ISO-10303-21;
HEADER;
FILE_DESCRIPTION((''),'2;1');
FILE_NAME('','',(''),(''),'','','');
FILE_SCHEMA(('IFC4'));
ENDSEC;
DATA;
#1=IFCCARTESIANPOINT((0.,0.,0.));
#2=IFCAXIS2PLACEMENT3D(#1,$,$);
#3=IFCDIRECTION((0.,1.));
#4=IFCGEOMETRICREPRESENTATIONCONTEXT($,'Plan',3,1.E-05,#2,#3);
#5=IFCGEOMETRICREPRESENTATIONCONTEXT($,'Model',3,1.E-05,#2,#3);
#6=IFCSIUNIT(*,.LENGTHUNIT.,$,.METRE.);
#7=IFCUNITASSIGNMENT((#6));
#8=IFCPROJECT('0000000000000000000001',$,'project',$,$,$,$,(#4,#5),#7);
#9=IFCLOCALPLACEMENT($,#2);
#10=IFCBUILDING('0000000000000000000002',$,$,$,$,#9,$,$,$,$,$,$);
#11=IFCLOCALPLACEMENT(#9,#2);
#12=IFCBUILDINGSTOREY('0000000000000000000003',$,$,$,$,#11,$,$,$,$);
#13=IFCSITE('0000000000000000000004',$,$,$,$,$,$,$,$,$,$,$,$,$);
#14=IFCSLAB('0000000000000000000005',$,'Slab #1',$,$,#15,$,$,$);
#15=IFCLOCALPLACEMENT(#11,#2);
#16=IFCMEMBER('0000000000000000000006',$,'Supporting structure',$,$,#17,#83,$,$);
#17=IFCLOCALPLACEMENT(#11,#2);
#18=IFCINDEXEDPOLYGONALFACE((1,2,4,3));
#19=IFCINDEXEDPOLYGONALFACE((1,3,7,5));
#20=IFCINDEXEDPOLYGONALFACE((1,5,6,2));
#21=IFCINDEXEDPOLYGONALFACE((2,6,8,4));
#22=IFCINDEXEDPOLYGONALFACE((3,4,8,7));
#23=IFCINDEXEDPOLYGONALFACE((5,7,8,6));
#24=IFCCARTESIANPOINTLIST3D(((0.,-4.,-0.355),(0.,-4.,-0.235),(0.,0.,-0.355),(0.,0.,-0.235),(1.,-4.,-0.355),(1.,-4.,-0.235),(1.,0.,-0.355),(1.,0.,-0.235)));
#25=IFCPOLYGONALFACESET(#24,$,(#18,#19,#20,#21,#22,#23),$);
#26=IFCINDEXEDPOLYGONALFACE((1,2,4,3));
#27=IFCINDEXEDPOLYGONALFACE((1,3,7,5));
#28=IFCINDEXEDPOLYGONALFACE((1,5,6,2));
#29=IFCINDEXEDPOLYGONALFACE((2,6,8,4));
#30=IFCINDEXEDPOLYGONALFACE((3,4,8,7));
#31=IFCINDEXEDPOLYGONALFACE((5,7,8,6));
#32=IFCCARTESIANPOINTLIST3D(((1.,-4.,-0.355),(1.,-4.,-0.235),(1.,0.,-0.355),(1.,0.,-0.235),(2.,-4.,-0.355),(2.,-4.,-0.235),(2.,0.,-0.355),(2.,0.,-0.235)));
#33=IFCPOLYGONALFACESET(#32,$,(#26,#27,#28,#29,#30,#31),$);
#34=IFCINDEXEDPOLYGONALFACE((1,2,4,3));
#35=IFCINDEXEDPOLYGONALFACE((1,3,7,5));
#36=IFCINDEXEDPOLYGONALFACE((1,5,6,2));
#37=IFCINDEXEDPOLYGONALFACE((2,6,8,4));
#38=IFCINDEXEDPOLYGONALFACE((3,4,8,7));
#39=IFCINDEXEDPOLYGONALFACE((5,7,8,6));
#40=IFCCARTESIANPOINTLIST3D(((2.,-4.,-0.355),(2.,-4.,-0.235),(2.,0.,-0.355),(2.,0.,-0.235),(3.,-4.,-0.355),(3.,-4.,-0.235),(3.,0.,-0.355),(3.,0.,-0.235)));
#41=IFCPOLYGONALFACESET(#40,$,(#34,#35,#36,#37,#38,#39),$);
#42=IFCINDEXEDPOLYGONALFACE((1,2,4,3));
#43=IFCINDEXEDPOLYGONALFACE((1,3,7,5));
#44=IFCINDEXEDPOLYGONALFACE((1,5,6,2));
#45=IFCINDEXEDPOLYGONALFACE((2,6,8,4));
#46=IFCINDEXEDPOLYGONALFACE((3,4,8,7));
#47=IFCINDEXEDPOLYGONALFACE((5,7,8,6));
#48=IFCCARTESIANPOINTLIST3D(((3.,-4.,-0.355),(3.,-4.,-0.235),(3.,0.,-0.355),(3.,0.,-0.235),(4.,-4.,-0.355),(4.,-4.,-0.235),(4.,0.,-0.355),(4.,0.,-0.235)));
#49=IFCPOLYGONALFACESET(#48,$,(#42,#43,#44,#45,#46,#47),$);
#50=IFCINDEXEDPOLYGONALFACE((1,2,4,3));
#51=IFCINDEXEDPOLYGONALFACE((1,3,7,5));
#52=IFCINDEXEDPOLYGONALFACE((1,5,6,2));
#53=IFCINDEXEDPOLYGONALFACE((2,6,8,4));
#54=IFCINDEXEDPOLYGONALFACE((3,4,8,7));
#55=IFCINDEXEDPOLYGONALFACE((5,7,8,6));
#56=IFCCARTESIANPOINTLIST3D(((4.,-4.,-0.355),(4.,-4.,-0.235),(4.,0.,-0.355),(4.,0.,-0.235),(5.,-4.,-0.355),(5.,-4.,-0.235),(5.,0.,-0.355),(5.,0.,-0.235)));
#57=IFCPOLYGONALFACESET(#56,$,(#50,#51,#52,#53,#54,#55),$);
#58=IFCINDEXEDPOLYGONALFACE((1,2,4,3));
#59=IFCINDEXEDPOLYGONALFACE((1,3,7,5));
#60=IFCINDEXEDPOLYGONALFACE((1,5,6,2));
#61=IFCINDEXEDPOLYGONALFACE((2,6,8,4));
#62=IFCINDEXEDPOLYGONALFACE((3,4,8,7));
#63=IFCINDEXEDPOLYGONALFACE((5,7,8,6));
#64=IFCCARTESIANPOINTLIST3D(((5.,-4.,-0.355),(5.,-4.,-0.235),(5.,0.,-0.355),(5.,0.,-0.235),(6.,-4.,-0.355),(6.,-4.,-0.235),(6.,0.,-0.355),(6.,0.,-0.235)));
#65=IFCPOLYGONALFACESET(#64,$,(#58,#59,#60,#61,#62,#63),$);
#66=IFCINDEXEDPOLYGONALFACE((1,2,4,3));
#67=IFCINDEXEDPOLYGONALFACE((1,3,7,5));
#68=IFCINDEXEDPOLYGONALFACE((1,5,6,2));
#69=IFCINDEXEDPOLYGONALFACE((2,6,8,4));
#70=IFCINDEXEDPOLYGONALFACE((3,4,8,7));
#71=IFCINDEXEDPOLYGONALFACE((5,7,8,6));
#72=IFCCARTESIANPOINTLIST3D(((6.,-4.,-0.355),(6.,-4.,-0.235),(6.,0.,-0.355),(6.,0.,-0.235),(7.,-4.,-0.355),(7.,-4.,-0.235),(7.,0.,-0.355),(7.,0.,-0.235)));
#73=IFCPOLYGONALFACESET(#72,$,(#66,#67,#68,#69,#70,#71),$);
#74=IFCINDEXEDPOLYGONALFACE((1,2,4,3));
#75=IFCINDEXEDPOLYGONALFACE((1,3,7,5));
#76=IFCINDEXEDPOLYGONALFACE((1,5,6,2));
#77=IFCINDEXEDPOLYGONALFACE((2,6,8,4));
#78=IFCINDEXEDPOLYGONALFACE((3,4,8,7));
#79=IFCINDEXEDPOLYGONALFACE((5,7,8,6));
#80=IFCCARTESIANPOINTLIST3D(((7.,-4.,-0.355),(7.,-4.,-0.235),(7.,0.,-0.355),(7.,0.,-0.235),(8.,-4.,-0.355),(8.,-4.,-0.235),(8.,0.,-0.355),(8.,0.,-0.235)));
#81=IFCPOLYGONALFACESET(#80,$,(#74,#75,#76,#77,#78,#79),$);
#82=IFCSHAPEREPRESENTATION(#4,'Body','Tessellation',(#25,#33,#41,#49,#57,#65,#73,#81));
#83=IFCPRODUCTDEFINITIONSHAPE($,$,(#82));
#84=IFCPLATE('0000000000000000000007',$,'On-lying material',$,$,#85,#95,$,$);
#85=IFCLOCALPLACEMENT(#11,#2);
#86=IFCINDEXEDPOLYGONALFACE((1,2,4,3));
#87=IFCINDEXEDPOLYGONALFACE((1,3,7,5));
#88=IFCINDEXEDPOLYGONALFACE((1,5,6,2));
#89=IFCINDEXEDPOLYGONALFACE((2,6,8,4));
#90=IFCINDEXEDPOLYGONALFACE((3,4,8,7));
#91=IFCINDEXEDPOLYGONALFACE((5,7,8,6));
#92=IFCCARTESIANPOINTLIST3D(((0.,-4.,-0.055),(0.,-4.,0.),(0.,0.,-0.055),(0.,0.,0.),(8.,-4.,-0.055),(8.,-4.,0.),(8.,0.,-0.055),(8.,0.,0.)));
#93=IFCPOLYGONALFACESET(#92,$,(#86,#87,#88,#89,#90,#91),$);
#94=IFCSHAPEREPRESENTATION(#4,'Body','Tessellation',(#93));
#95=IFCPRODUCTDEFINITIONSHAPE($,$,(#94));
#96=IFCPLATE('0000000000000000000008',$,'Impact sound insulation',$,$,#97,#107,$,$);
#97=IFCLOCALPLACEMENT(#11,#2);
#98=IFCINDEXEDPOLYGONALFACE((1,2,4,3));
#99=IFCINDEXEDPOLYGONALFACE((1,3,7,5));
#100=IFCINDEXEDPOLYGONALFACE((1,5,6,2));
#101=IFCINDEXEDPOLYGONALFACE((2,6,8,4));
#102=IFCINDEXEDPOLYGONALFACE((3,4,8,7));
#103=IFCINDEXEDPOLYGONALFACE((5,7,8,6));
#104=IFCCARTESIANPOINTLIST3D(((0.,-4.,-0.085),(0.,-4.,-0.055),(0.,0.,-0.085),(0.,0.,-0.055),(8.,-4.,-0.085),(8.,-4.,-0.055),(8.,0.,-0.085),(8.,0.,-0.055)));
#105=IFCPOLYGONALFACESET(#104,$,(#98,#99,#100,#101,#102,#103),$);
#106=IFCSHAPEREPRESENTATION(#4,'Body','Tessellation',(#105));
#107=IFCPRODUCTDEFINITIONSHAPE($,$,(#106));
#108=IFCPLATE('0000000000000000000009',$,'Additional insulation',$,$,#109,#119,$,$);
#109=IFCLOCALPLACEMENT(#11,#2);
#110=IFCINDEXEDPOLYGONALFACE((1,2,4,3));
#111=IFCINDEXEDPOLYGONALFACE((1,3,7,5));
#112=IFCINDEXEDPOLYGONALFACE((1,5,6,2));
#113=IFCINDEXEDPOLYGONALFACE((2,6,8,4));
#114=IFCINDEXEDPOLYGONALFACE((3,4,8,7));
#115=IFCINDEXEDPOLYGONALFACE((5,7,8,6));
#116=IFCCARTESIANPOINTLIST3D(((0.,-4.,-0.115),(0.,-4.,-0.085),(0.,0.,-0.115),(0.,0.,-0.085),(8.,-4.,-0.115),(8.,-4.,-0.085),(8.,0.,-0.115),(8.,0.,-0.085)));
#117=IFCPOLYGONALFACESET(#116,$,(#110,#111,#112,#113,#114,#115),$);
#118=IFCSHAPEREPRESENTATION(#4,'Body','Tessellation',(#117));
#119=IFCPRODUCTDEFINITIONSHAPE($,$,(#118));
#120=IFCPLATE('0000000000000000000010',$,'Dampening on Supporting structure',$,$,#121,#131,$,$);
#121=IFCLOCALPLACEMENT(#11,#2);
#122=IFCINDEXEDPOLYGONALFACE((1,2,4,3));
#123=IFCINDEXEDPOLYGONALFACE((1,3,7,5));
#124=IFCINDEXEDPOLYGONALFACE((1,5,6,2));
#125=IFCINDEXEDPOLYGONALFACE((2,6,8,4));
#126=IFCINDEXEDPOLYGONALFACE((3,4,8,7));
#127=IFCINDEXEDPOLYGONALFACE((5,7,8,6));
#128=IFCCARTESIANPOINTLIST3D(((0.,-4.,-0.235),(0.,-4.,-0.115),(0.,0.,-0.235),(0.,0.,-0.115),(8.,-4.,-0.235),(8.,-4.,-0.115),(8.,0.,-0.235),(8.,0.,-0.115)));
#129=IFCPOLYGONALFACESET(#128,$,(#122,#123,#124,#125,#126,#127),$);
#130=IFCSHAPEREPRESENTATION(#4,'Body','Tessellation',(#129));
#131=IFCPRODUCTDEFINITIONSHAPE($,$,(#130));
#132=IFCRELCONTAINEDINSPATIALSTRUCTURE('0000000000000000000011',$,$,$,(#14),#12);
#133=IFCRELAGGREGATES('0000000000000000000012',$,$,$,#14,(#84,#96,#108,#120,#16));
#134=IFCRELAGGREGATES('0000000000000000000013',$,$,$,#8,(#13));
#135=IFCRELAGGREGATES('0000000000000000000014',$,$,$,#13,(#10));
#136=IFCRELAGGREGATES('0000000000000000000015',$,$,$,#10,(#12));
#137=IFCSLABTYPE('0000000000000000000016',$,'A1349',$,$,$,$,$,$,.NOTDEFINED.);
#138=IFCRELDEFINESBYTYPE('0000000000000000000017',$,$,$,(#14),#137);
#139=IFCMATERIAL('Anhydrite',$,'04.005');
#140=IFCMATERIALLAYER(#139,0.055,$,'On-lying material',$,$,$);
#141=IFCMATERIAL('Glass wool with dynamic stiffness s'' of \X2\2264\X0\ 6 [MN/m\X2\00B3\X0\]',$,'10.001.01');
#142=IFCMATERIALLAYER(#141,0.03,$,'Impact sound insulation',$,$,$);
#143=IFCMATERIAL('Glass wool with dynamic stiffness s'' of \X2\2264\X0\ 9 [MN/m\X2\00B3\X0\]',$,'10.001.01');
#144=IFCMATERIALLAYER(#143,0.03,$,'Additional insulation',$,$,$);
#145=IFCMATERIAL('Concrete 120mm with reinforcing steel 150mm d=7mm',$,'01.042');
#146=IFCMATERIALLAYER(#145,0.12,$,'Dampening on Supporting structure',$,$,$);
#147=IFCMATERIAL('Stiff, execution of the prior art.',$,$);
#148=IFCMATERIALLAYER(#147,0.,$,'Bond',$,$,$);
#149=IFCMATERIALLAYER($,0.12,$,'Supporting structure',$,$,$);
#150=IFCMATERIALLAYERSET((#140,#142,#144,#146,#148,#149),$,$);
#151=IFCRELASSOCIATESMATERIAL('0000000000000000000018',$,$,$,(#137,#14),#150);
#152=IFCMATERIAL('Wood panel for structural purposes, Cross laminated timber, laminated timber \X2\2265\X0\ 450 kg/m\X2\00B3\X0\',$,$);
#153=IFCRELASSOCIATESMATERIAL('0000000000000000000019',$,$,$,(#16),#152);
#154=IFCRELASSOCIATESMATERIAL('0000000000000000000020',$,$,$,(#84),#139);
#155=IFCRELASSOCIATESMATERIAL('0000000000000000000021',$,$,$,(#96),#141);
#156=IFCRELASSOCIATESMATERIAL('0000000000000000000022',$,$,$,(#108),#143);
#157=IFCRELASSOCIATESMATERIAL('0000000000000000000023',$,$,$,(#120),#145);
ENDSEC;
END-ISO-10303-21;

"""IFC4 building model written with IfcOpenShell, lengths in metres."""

from ifc_helpers import new_model, si_unit, direction, frame, frame_2d, origin, origin_with_axes, place, context, project, spatial, rectangle, extrude, material, layer, layer_set, type_object, element, aggregate, save


model = new_model("IFC4")

# Units and contexts
plan_context = context("Plan", 3, precision=1e-05, world=origin(), true_north=direction((0.0, 1.0)))
model_context = context("Model", 3, precision=1e-05, world=origin(), true_north=direction((0.0, 1.0)))
ifc_project = project(units=[si_unit("LENGTHUNIT", "METRE")], contexts=[plan_context, model_context])

# Site, building, storey
site = spatial("IfcSite", under=ifc_project)
building_placement = place(None, origin())
building = spatial("IfcBuilding", under=site, at=building_placement)
storey_placement = place(building_placement, origin())
storey = spatial("IfcBuildingStorey", under=building, at=storey_placement)

# Slab, member, plates
ifc_material_1 = material(Name="Anhydrite", Category="04.005")
ifc_layer_1 = layer(ifc_material_1, 0.055, Name="On-lying material")
ifc_material_2 = material(Name="Glass wool with dynamic stiffness s' of ≤ 6 [MN/m³]", Category="10.001.01")
ifc_layer_2 = layer(ifc_material_2, 0.03, Name="Impact sound insulation")
ifc_material_3 = material(Name="Glass wool with dynamic stiffness s' of ≤ 9 [MN/m³]", Category="10.001.01")
ifc_layer_3 = layer(ifc_material_3, 0.03, Name="Additional insulation")
ifc_material_4 = material(Name="Concrete 120mm with reinforcing steel 150mm d=7mm", Category="01.042")
ifc_layer_4 = layer(ifc_material_4, 0.12, Name="Dampening on Supporting structure")
ifc_material_5 = material(Name="Stiff, execution of the prior art.")
ifc_layer_5 = layer(ifc_material_5, 0.0, Name="Bond")
ifc_layer_6 = layer(None, 0.12, Name="Supporting structure")
ifc_layer_set = layer_set([ifc_layer_1, ifc_layer_2, ifc_layer_3, ifc_layer_4, ifc_layer_5, ifc_layer_6])
slab_type = type_object("IfcSlabType", Name="A1349", PredefinedType="NOTDEFINED", material=ifc_layer_set)
slab_placement = place(None, frame((0.0, 0.0, 0.0), z_axis=(0.0, 0.0, -1.0), x_axis=(1.0, 0.0, 0.0)))
slab = element("IfcSlab", 1, at=slab_placement, inside=storey, type_object=slab_type, material=ifc_layer_set, Name="Slab #1")
ifc_material_6 = material(Name="Wood panel for structural purposes, Cross laminated timber, laminated timber ≥ 450 kg/m³")
member_placement = place(slab_placement, origin())
member = element("IfcMember", 2, at=member_placement, material=ifc_material_6, Name="Supporting structure", context=plan_context, shape_type="SweptSolid", body=[
    extrude(rectangle(XDim=1.0, YDim=0.12, at=frame_2d((0.5, 0.06), x_axis=(1.0, 0.0))), frame((0.0, 4.0, 0.235), z_axis=(0.0, -1.0, 0.0), x_axis=(1.0, 0.0, 0.0)), (0.0, 0.0, 1.0), 4.0),
    extrude(rectangle(XDim=1.0, YDim=0.12, at=frame_2d((0.5, 0.06), x_axis=(1.0, 0.0))), frame((1.0, 4.0, 0.235), z_axis=(0.0, -1.0, 0.0), x_axis=(1.0, 0.0, 0.0)), (0.0, 0.0, 1.0), 4.0),
    extrude(rectangle(XDim=1.0, YDim=0.12, at=frame_2d((0.5, 0.06), x_axis=(1.0, 0.0))), frame((2.0, 4.0, 0.235), z_axis=(0.0, -1.0, 0.0), x_axis=(1.0, 0.0, 0.0)), (0.0, 0.0, 1.0), 4.0),
    extrude(rectangle(XDim=1.0, YDim=0.12, at=frame_2d((0.5, 0.06), x_axis=(1.0, 0.0))), frame((3.0, 4.0, 0.235), z_axis=(0.0, -1.0, 0.0), x_axis=(1.0, 0.0, 0.0)), (0.0, 0.0, 1.0), 4.0),
    extrude(rectangle(XDim=1.0, YDim=0.12, at=frame_2d((0.5, 0.06), x_axis=(1.0, 0.0))), frame((4.0, 4.0, 0.235), z_axis=(0.0, -1.0, 0.0), x_axis=(1.0, 0.0, 0.0)), (0.0, 0.0, 1.0), 4.0),
    extrude(rectangle(XDim=1.0, YDim=0.12, at=frame_2d((0.5, 0.06), x_axis=(1.0, 0.0))), frame((5.0, 4.0, 0.235), z_axis=(0.0, -1.0, 0.0), x_axis=(1.0, 0.0, 0.0)), (0.0, 0.0, 1.0), 4.0),
    extrude(rectangle(XDim=1.0, YDim=0.12, at=frame_2d((0.5, 0.06), x_axis=(1.0, 0.0))), frame((6.0, 4.0, 0.235), z_axis=(0.0, -1.0, 0.0), x_axis=(1.0, 0.0, 0.0)), (0.0, 0.0, 1.0), 4.0),
    extrude(rectangle(XDim=1.0, YDim=0.12, at=frame_2d((0.5, 0.06), x_axis=(1.0, 0.0))), frame((7.0, 4.0, 0.235), z_axis=(0.0, -1.0, 0.0), x_axis=(1.0, 0.0, 0.0)), (0.0, 0.0, 1.0), 4.0),
])
plate_1_placement = place(slab_placement, origin())
plate_1 = element("IfcPlate", 3, at=plate_1_placement, material=ifc_material_1, Name="On-lying material", context=plan_context, shape_type="SweptSolid", body=[
    extrude(rectangle(XDim=8.0, YDim=4.0, at=frame_2d((4.0, 2.0), x_axis=(1.0, 0.0))), origin_with_axes(), (0.0, 0.0, 1.0), 0.055),
])
plate_2_placement = place(slab_placement, origin())
plate_2 = element("IfcPlate", 4, at=plate_2_placement, material=ifc_material_2, Name="Impact sound insulation", context=plan_context, shape_type="SweptSolid", body=[
    extrude(rectangle(XDim=8.0, YDim=4.0, at=frame_2d((4.0, 2.0), x_axis=(1.0, 0.0))), frame((0.0, 0.0, 0.055), z_axis=(0.0, 0.0, 1.0), x_axis=(1.0, 0.0, 0.0)), (0.0, 0.0, 1.0), 0.03),
])
plate_3_placement = place(slab_placement, origin())
plate_3 = element("IfcPlate", 5, at=plate_3_placement, material=ifc_material_3, Name="Additional insulation", context=plan_context, shape_type="SweptSolid", body=[
    extrude(rectangle(XDim=8.0, YDim=4.0, at=frame_2d((4.0, 2.0), x_axis=(1.0, 0.0))), frame((0.0, 0.0, 0.085), z_axis=(0.0, 0.0, 1.0), x_axis=(1.0, 0.0, 0.0)), (0.0, 0.0, 1.0), 0.03),
])
plate_4_placement = place(slab_placement, origin())
plate_4 = element("IfcPlate", 6, at=plate_4_placement, material=ifc_material_4, Name="Dampening on Supporting structure", context=plan_context, shape_type="SweptSolid", body=[
    extrude(rectangle(XDim=8.0, YDim=4.0, at=frame_2d((4.0, 2.0), x_axis=(1.0, 0.0))), frame((0.0, 0.0, 0.115), z_axis=(0.0, 0.0, 1.0), x_axis=(1.0, 0.0, 0.0)), (0.0, 0.0, 1.0), 0.12),
])
aggregate(slab, [plate_1, plate_2, plate_3, plate_4, member])

save(model, "model.ifc")
